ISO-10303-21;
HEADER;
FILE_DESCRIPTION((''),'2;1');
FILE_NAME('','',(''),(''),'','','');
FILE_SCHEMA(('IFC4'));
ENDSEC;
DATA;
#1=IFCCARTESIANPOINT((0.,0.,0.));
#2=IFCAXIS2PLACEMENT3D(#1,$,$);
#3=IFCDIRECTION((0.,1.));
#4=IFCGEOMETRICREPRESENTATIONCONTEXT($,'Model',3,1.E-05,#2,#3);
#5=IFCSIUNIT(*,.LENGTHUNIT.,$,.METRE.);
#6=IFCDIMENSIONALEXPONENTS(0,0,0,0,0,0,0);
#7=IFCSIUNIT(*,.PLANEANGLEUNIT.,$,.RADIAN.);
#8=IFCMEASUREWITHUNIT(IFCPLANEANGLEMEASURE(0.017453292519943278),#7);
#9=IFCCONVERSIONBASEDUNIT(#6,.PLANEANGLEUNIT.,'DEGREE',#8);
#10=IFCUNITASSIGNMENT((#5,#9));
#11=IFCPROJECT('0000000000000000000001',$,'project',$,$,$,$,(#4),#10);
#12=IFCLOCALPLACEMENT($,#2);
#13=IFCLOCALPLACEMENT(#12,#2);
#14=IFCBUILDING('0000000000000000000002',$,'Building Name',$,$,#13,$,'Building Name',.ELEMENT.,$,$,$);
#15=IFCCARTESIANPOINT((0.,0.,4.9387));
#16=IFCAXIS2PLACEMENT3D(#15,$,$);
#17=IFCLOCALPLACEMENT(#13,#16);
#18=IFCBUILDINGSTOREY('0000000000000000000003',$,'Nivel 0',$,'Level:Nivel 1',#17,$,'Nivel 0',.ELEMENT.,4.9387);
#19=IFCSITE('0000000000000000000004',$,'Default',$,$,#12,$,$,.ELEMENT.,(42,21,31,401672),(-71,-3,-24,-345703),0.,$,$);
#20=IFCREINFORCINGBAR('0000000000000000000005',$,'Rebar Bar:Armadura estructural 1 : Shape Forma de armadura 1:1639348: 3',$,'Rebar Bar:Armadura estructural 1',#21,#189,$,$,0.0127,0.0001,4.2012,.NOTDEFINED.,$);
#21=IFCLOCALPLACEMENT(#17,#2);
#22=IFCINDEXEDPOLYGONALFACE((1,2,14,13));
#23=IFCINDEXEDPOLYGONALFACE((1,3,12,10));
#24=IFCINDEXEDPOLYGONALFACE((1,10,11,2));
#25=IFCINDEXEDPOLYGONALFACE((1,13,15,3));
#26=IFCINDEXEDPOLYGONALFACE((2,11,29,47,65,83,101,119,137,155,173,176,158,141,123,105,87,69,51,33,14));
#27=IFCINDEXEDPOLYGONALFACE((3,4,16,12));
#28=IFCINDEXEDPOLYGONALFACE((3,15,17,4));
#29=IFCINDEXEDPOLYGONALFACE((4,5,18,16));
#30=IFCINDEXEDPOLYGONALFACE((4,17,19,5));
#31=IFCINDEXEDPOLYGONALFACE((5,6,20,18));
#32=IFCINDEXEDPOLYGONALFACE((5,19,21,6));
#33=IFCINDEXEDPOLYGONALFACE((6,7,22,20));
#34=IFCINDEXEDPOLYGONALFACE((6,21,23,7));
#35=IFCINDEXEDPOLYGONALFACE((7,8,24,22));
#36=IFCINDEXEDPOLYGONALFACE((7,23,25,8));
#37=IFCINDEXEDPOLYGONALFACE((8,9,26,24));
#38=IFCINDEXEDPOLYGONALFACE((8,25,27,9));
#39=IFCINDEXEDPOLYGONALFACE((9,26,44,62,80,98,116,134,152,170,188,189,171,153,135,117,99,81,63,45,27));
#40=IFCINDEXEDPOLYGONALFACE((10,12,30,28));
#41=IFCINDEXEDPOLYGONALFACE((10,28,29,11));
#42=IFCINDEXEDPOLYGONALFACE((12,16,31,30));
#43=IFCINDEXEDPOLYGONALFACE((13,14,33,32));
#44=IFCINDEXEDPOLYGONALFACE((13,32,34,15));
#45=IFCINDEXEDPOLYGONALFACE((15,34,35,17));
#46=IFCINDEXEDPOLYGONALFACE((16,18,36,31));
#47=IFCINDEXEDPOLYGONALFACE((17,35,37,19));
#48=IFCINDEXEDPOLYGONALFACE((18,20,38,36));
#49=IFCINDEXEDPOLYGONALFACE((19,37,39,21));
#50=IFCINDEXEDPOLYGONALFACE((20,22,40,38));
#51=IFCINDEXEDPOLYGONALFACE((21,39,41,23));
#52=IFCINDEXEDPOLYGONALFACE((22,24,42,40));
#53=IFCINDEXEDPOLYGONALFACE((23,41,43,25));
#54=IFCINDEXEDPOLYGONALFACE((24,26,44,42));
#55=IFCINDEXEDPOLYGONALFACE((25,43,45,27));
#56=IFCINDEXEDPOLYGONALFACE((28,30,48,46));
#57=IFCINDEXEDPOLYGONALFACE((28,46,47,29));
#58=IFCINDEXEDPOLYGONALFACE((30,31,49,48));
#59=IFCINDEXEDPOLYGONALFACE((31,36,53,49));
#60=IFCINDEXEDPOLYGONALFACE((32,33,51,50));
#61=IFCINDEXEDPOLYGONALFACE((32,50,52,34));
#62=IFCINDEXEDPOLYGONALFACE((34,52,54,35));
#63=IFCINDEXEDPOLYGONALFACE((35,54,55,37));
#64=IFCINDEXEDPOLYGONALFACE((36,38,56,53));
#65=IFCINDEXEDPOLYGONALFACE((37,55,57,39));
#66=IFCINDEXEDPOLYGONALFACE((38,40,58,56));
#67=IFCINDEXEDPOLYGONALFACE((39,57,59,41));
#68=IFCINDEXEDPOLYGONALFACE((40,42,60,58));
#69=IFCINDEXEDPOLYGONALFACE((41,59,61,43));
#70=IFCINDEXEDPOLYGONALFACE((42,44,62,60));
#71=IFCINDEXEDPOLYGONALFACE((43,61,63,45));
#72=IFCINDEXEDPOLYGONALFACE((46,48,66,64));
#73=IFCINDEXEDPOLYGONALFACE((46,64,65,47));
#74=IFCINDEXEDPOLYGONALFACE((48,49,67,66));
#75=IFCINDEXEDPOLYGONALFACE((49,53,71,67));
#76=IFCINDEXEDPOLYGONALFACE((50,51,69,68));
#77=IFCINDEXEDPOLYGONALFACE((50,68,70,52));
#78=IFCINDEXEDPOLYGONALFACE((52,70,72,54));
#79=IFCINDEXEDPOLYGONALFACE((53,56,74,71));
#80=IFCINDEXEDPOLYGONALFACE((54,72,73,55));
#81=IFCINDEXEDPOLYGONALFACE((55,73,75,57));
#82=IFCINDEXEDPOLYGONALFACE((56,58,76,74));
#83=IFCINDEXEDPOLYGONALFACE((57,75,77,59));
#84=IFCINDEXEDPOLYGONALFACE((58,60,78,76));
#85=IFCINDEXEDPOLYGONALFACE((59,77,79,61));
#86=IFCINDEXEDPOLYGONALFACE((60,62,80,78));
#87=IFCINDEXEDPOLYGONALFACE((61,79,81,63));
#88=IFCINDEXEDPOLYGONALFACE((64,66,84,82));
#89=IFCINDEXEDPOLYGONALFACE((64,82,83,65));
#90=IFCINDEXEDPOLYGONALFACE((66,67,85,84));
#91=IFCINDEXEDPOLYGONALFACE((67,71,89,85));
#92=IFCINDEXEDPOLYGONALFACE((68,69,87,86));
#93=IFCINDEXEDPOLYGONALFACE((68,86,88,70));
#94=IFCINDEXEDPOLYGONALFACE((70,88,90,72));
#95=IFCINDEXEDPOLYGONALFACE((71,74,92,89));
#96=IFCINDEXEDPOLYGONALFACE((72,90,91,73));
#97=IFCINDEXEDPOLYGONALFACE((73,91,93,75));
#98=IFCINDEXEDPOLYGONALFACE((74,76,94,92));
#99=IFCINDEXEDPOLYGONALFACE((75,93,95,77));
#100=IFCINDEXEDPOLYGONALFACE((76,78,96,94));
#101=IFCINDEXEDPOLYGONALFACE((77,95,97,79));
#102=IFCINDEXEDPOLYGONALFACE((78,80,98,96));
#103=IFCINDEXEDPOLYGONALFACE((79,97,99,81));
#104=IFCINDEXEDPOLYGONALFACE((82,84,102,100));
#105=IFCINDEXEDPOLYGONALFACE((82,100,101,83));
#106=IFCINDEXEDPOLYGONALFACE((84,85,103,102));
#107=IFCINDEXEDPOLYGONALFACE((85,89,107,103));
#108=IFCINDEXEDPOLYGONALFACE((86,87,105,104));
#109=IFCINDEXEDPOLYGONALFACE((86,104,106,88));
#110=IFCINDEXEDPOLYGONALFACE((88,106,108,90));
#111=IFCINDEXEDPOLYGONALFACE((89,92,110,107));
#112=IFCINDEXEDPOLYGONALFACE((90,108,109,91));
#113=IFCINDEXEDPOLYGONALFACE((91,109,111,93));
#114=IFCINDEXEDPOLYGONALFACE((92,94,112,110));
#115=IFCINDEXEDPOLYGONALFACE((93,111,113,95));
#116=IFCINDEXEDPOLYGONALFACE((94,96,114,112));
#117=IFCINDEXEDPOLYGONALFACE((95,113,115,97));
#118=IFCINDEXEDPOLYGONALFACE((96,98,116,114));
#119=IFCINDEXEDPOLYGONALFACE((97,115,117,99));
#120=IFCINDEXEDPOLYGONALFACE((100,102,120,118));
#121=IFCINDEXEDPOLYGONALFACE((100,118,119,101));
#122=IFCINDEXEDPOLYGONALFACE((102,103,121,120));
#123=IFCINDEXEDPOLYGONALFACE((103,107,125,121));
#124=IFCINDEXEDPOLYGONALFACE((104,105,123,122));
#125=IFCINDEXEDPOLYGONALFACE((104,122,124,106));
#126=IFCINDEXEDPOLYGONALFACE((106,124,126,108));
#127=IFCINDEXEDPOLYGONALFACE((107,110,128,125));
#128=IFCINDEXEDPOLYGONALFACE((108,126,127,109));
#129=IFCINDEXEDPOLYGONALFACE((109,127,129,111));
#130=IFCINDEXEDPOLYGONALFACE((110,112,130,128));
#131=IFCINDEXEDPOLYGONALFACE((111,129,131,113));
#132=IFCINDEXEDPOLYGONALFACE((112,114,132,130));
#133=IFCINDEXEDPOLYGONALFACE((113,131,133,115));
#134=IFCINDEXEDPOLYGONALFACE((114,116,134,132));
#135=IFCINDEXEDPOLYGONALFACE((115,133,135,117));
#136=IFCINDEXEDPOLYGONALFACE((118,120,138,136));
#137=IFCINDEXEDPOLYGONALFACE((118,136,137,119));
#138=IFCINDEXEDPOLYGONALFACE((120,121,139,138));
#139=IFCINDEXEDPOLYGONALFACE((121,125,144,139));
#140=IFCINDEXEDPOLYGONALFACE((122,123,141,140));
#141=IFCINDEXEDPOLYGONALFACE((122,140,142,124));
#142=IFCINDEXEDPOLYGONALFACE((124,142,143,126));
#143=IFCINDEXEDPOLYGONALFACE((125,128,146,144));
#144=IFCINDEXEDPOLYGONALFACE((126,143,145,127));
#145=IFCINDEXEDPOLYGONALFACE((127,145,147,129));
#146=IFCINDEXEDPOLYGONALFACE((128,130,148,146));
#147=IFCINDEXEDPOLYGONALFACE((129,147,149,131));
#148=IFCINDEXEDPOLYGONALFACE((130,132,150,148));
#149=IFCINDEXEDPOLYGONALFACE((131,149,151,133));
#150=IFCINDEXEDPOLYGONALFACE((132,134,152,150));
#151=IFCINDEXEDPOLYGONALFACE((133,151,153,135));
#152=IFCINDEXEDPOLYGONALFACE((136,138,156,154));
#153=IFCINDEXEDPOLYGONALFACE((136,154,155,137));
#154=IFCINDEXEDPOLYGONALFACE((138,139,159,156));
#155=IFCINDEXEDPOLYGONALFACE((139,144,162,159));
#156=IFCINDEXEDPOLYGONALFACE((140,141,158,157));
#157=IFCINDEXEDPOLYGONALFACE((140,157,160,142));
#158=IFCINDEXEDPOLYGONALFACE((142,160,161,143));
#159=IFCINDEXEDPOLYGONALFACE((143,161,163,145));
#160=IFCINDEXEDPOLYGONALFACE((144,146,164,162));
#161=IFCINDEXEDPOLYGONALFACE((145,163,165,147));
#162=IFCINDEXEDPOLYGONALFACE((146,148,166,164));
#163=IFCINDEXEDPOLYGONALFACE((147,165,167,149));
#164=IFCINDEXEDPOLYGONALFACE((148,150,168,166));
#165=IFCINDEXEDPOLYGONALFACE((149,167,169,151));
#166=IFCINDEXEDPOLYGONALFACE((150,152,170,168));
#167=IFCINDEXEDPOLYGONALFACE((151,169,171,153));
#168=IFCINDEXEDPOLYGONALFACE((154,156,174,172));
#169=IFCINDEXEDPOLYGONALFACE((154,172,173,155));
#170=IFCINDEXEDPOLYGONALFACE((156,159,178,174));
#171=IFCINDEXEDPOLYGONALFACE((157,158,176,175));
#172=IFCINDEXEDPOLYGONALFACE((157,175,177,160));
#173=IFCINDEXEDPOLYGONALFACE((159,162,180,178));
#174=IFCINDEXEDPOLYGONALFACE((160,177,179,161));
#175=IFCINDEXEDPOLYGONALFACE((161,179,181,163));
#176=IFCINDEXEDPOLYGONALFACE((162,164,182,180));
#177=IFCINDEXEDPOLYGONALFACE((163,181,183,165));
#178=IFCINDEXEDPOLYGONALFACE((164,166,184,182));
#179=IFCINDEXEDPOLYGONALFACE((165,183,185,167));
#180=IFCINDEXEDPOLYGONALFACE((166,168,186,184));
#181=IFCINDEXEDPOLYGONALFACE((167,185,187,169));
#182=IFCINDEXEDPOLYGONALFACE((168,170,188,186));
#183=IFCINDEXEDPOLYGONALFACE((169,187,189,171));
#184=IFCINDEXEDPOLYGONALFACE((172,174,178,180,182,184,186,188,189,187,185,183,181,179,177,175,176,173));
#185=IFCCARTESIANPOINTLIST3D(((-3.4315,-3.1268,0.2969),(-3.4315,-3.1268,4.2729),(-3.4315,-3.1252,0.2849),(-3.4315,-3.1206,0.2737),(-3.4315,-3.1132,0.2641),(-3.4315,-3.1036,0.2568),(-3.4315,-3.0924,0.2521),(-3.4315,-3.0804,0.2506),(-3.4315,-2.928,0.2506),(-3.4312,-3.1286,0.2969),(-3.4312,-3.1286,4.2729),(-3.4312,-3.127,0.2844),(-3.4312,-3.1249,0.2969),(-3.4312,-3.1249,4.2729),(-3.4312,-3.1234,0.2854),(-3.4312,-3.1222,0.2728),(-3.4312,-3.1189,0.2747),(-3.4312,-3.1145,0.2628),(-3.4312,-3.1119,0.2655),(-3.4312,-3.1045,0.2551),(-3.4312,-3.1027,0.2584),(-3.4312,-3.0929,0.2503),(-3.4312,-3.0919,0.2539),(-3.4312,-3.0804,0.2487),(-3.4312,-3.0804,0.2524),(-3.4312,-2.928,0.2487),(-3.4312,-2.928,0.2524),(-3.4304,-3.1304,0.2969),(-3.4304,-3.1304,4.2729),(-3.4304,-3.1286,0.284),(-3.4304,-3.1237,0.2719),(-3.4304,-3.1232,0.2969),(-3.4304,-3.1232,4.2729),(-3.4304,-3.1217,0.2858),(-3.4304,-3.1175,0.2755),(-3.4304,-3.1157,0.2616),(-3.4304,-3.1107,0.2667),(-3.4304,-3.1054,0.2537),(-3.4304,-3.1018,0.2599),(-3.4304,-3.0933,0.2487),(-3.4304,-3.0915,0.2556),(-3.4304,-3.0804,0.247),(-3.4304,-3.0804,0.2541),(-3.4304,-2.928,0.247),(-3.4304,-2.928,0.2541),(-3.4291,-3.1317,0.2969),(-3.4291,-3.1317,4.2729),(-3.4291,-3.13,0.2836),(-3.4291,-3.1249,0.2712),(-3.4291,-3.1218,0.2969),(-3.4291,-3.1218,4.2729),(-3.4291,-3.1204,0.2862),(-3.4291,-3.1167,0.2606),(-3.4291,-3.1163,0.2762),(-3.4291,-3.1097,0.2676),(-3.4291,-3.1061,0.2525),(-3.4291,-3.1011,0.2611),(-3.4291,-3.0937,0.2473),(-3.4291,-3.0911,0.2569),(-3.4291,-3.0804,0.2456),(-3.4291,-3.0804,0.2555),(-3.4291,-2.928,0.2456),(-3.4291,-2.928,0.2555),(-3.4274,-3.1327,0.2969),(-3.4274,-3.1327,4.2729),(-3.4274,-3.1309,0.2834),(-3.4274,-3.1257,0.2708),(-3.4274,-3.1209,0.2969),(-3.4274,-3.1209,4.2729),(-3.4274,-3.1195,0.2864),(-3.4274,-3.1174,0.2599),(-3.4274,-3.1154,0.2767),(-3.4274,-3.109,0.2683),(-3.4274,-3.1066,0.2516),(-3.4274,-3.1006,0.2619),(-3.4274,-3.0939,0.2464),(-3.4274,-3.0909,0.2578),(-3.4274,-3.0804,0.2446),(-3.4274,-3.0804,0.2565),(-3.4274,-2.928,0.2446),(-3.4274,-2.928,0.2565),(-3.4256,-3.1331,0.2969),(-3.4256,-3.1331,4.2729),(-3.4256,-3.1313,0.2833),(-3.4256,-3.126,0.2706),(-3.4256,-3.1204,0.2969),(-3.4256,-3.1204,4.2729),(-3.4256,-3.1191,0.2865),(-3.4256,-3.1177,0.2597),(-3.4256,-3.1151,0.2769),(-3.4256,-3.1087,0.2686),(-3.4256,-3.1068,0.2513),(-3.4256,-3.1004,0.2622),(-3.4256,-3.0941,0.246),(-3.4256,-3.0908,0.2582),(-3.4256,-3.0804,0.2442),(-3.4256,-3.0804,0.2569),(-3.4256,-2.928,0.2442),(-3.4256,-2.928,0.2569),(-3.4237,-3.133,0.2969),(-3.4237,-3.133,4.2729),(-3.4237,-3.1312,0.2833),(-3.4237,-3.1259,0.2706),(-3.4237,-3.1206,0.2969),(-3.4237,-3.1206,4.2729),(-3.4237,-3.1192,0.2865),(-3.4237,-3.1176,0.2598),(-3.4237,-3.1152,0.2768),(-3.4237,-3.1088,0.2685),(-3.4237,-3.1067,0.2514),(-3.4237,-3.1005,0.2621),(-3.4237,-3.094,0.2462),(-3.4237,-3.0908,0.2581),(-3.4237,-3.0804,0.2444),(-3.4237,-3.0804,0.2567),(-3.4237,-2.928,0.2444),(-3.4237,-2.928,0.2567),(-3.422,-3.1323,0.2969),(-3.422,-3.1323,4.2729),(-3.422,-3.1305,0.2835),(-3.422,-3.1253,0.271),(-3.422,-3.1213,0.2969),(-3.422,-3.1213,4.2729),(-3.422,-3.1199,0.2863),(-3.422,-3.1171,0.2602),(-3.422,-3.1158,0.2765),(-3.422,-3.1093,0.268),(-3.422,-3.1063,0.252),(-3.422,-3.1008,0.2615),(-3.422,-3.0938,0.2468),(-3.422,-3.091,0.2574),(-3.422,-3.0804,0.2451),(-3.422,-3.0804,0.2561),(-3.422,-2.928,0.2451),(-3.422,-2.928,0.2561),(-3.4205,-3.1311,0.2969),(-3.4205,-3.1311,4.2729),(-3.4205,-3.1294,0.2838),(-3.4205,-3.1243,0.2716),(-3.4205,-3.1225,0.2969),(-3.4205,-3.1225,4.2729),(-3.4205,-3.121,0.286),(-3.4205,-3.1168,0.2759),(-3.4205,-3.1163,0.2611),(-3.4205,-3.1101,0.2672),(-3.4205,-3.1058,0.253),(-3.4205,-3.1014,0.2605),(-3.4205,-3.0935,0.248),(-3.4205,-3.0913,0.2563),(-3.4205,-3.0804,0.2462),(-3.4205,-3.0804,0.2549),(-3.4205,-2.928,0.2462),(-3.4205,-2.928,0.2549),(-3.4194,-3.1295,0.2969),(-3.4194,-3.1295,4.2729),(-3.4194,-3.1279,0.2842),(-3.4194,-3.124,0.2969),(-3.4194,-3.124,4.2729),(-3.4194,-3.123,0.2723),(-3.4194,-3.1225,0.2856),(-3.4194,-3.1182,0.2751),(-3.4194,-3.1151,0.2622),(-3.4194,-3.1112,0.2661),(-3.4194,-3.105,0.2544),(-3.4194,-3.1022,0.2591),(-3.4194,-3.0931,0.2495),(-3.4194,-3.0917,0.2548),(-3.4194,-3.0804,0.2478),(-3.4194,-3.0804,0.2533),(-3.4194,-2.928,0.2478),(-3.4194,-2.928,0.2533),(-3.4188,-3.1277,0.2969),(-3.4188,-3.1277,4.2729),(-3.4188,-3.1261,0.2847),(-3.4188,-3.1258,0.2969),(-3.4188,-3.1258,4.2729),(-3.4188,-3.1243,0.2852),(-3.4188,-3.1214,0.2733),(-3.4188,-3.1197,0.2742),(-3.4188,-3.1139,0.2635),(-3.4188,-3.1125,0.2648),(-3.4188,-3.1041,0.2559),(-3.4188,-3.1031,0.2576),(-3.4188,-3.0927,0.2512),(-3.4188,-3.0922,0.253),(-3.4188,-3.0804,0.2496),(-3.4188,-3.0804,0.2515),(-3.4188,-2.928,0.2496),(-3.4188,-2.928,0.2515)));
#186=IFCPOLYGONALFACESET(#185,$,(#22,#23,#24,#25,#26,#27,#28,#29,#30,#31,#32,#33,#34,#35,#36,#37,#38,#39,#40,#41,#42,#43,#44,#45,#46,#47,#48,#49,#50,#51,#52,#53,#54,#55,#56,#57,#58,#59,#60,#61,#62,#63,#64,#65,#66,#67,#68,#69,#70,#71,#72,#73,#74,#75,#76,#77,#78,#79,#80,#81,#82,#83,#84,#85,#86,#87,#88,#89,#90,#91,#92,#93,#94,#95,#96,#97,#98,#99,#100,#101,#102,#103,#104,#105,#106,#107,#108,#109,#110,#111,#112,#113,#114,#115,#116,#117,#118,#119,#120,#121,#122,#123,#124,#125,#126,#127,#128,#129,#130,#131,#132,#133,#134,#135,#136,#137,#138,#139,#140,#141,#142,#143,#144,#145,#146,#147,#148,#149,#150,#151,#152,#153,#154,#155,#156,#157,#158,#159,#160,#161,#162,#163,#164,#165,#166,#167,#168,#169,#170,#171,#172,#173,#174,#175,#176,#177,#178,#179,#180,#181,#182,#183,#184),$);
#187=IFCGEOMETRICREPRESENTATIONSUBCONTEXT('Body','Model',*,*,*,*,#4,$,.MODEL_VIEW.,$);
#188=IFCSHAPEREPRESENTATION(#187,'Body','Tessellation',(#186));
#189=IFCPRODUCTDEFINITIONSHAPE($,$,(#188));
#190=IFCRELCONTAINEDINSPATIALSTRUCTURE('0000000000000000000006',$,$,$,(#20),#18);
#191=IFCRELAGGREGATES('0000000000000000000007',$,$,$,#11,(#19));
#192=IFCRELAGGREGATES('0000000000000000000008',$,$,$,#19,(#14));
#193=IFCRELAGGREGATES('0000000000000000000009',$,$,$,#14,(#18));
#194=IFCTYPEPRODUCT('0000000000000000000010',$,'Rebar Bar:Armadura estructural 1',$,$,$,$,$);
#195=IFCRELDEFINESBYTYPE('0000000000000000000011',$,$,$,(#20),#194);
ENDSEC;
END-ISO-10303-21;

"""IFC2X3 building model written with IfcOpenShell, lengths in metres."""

from ifc_helpers import new_model, entity, si_unit, converted_unit, direction, frame, origin, place, context, subcontext, project, spatial, type_object, element, save


model = new_model("IFC2X3")

# Units and contexts
model_context = context("Model", 3, precision=1e-05, world=origin(), true_north=direction((0.0, 1.0)))
body_context = subcontext(model_context, "Body", "Model", "MODEL_VIEW")
ifc_project = project(units=[si_unit("LENGTHUNIT", "METRE"), converted_unit("PLANEANGLEUNIT", "DEGREE", entity("IfcPlaneAngleMeasure", 0.017453292519943278), si_unit("PLANEANGLEUNIT", "RADIAN"), dimensions=[0, 0, 0, 0, 0, 0, 0])], contexts=[model_context])

# Site, building, storey
site_placement = place(None, origin())
site = spatial("IfcSite", under=ifc_project, at=site_placement, Name="Default", CompositionType="ELEMENT", RefLatitude=(42, 21, 31, 401672), RefLongitude=(-71, -3, -24, -345703), RefElevation=0.0)
building_placement = place(site_placement, origin())
building = spatial("IfcBuilding", under=site, at=building_placement, Name="Building Name", LongName="Building Name", CompositionType="ELEMENT")
storey_placement = place(building_placement, frame((0.0, 0.0, 4.9387)))
storey = spatial("IfcBuildingStorey", under=building, at=storey_placement, Name="Nivel 0", ObjectType="Level:Nivel 1", LongName="Nivel 0", CompositionType="ELEMENT", Elevation=4.9387)

# Reinforcing bar
type_product = type_object("IfcTypeProduct", Name="Rebar Bar:Armadura estructural 1")
reinforcing_bar_1_placement = place(storey_placement, origin())
element("IfcReinforcingBar", 1, at=reinforcing_bar_1_placement, inside=storey, type_object=type_product, Name="Rebar Bar:Armadura estructural 1 : Shape Forma de armadura 1:1639348: 3", ObjectType="Rebar Bar:Armadura estructural 1", BarLength=4.2012, BarRole="NOTDEFINED", CrossSectionArea=0.0001, NominalDiameter=0.0127, context=body_context, shape_type="AdvancedSweptSolid", body=[
    entity("IfcSweptDiskSolid", entity("IfcCompositeCurve", [entity("IfcCompositeCurveSegment", "CONTINUOUS", True, entity("IfcPolyline", [entity("IfcCartesianPoint", [-3.4251, -2.928, 0.2506]), entity("IfcCartesianPoint", [-3.4251, -3.0804, 0.2506])])), entity("IfcCompositeCurveSegment", "CONTINUOUS", True, entity("IfcTrimmedCurve", entity("IfcCircle", entity("IfcAxis2Placement3D", entity("IfcCartesianPoint", [-3.4251, -3.0804, 0.2969]), entity("IfcDirection", [-1.0, 0.0, 0.0]), entity("IfcDirection", [0.0, -1.0, 0.0])), 0.0464), [entity("IfcParameterValue", 270.0)], [entity("IfcParameterValue", 360.0)], True, "PARAMETER")), entity("IfcCompositeCurveSegment", "CONTINUOUS", True, entity("IfcPolyline", [entity("IfcCartesianPoint", [-3.4251, -3.1268, 0.2969]), entity("IfcCartesianPoint", [-3.4251, -3.1268, 4.2729])]))], False), 0.0063, None, 0.0, 92.0),
])

save(model, "model.ifc")
